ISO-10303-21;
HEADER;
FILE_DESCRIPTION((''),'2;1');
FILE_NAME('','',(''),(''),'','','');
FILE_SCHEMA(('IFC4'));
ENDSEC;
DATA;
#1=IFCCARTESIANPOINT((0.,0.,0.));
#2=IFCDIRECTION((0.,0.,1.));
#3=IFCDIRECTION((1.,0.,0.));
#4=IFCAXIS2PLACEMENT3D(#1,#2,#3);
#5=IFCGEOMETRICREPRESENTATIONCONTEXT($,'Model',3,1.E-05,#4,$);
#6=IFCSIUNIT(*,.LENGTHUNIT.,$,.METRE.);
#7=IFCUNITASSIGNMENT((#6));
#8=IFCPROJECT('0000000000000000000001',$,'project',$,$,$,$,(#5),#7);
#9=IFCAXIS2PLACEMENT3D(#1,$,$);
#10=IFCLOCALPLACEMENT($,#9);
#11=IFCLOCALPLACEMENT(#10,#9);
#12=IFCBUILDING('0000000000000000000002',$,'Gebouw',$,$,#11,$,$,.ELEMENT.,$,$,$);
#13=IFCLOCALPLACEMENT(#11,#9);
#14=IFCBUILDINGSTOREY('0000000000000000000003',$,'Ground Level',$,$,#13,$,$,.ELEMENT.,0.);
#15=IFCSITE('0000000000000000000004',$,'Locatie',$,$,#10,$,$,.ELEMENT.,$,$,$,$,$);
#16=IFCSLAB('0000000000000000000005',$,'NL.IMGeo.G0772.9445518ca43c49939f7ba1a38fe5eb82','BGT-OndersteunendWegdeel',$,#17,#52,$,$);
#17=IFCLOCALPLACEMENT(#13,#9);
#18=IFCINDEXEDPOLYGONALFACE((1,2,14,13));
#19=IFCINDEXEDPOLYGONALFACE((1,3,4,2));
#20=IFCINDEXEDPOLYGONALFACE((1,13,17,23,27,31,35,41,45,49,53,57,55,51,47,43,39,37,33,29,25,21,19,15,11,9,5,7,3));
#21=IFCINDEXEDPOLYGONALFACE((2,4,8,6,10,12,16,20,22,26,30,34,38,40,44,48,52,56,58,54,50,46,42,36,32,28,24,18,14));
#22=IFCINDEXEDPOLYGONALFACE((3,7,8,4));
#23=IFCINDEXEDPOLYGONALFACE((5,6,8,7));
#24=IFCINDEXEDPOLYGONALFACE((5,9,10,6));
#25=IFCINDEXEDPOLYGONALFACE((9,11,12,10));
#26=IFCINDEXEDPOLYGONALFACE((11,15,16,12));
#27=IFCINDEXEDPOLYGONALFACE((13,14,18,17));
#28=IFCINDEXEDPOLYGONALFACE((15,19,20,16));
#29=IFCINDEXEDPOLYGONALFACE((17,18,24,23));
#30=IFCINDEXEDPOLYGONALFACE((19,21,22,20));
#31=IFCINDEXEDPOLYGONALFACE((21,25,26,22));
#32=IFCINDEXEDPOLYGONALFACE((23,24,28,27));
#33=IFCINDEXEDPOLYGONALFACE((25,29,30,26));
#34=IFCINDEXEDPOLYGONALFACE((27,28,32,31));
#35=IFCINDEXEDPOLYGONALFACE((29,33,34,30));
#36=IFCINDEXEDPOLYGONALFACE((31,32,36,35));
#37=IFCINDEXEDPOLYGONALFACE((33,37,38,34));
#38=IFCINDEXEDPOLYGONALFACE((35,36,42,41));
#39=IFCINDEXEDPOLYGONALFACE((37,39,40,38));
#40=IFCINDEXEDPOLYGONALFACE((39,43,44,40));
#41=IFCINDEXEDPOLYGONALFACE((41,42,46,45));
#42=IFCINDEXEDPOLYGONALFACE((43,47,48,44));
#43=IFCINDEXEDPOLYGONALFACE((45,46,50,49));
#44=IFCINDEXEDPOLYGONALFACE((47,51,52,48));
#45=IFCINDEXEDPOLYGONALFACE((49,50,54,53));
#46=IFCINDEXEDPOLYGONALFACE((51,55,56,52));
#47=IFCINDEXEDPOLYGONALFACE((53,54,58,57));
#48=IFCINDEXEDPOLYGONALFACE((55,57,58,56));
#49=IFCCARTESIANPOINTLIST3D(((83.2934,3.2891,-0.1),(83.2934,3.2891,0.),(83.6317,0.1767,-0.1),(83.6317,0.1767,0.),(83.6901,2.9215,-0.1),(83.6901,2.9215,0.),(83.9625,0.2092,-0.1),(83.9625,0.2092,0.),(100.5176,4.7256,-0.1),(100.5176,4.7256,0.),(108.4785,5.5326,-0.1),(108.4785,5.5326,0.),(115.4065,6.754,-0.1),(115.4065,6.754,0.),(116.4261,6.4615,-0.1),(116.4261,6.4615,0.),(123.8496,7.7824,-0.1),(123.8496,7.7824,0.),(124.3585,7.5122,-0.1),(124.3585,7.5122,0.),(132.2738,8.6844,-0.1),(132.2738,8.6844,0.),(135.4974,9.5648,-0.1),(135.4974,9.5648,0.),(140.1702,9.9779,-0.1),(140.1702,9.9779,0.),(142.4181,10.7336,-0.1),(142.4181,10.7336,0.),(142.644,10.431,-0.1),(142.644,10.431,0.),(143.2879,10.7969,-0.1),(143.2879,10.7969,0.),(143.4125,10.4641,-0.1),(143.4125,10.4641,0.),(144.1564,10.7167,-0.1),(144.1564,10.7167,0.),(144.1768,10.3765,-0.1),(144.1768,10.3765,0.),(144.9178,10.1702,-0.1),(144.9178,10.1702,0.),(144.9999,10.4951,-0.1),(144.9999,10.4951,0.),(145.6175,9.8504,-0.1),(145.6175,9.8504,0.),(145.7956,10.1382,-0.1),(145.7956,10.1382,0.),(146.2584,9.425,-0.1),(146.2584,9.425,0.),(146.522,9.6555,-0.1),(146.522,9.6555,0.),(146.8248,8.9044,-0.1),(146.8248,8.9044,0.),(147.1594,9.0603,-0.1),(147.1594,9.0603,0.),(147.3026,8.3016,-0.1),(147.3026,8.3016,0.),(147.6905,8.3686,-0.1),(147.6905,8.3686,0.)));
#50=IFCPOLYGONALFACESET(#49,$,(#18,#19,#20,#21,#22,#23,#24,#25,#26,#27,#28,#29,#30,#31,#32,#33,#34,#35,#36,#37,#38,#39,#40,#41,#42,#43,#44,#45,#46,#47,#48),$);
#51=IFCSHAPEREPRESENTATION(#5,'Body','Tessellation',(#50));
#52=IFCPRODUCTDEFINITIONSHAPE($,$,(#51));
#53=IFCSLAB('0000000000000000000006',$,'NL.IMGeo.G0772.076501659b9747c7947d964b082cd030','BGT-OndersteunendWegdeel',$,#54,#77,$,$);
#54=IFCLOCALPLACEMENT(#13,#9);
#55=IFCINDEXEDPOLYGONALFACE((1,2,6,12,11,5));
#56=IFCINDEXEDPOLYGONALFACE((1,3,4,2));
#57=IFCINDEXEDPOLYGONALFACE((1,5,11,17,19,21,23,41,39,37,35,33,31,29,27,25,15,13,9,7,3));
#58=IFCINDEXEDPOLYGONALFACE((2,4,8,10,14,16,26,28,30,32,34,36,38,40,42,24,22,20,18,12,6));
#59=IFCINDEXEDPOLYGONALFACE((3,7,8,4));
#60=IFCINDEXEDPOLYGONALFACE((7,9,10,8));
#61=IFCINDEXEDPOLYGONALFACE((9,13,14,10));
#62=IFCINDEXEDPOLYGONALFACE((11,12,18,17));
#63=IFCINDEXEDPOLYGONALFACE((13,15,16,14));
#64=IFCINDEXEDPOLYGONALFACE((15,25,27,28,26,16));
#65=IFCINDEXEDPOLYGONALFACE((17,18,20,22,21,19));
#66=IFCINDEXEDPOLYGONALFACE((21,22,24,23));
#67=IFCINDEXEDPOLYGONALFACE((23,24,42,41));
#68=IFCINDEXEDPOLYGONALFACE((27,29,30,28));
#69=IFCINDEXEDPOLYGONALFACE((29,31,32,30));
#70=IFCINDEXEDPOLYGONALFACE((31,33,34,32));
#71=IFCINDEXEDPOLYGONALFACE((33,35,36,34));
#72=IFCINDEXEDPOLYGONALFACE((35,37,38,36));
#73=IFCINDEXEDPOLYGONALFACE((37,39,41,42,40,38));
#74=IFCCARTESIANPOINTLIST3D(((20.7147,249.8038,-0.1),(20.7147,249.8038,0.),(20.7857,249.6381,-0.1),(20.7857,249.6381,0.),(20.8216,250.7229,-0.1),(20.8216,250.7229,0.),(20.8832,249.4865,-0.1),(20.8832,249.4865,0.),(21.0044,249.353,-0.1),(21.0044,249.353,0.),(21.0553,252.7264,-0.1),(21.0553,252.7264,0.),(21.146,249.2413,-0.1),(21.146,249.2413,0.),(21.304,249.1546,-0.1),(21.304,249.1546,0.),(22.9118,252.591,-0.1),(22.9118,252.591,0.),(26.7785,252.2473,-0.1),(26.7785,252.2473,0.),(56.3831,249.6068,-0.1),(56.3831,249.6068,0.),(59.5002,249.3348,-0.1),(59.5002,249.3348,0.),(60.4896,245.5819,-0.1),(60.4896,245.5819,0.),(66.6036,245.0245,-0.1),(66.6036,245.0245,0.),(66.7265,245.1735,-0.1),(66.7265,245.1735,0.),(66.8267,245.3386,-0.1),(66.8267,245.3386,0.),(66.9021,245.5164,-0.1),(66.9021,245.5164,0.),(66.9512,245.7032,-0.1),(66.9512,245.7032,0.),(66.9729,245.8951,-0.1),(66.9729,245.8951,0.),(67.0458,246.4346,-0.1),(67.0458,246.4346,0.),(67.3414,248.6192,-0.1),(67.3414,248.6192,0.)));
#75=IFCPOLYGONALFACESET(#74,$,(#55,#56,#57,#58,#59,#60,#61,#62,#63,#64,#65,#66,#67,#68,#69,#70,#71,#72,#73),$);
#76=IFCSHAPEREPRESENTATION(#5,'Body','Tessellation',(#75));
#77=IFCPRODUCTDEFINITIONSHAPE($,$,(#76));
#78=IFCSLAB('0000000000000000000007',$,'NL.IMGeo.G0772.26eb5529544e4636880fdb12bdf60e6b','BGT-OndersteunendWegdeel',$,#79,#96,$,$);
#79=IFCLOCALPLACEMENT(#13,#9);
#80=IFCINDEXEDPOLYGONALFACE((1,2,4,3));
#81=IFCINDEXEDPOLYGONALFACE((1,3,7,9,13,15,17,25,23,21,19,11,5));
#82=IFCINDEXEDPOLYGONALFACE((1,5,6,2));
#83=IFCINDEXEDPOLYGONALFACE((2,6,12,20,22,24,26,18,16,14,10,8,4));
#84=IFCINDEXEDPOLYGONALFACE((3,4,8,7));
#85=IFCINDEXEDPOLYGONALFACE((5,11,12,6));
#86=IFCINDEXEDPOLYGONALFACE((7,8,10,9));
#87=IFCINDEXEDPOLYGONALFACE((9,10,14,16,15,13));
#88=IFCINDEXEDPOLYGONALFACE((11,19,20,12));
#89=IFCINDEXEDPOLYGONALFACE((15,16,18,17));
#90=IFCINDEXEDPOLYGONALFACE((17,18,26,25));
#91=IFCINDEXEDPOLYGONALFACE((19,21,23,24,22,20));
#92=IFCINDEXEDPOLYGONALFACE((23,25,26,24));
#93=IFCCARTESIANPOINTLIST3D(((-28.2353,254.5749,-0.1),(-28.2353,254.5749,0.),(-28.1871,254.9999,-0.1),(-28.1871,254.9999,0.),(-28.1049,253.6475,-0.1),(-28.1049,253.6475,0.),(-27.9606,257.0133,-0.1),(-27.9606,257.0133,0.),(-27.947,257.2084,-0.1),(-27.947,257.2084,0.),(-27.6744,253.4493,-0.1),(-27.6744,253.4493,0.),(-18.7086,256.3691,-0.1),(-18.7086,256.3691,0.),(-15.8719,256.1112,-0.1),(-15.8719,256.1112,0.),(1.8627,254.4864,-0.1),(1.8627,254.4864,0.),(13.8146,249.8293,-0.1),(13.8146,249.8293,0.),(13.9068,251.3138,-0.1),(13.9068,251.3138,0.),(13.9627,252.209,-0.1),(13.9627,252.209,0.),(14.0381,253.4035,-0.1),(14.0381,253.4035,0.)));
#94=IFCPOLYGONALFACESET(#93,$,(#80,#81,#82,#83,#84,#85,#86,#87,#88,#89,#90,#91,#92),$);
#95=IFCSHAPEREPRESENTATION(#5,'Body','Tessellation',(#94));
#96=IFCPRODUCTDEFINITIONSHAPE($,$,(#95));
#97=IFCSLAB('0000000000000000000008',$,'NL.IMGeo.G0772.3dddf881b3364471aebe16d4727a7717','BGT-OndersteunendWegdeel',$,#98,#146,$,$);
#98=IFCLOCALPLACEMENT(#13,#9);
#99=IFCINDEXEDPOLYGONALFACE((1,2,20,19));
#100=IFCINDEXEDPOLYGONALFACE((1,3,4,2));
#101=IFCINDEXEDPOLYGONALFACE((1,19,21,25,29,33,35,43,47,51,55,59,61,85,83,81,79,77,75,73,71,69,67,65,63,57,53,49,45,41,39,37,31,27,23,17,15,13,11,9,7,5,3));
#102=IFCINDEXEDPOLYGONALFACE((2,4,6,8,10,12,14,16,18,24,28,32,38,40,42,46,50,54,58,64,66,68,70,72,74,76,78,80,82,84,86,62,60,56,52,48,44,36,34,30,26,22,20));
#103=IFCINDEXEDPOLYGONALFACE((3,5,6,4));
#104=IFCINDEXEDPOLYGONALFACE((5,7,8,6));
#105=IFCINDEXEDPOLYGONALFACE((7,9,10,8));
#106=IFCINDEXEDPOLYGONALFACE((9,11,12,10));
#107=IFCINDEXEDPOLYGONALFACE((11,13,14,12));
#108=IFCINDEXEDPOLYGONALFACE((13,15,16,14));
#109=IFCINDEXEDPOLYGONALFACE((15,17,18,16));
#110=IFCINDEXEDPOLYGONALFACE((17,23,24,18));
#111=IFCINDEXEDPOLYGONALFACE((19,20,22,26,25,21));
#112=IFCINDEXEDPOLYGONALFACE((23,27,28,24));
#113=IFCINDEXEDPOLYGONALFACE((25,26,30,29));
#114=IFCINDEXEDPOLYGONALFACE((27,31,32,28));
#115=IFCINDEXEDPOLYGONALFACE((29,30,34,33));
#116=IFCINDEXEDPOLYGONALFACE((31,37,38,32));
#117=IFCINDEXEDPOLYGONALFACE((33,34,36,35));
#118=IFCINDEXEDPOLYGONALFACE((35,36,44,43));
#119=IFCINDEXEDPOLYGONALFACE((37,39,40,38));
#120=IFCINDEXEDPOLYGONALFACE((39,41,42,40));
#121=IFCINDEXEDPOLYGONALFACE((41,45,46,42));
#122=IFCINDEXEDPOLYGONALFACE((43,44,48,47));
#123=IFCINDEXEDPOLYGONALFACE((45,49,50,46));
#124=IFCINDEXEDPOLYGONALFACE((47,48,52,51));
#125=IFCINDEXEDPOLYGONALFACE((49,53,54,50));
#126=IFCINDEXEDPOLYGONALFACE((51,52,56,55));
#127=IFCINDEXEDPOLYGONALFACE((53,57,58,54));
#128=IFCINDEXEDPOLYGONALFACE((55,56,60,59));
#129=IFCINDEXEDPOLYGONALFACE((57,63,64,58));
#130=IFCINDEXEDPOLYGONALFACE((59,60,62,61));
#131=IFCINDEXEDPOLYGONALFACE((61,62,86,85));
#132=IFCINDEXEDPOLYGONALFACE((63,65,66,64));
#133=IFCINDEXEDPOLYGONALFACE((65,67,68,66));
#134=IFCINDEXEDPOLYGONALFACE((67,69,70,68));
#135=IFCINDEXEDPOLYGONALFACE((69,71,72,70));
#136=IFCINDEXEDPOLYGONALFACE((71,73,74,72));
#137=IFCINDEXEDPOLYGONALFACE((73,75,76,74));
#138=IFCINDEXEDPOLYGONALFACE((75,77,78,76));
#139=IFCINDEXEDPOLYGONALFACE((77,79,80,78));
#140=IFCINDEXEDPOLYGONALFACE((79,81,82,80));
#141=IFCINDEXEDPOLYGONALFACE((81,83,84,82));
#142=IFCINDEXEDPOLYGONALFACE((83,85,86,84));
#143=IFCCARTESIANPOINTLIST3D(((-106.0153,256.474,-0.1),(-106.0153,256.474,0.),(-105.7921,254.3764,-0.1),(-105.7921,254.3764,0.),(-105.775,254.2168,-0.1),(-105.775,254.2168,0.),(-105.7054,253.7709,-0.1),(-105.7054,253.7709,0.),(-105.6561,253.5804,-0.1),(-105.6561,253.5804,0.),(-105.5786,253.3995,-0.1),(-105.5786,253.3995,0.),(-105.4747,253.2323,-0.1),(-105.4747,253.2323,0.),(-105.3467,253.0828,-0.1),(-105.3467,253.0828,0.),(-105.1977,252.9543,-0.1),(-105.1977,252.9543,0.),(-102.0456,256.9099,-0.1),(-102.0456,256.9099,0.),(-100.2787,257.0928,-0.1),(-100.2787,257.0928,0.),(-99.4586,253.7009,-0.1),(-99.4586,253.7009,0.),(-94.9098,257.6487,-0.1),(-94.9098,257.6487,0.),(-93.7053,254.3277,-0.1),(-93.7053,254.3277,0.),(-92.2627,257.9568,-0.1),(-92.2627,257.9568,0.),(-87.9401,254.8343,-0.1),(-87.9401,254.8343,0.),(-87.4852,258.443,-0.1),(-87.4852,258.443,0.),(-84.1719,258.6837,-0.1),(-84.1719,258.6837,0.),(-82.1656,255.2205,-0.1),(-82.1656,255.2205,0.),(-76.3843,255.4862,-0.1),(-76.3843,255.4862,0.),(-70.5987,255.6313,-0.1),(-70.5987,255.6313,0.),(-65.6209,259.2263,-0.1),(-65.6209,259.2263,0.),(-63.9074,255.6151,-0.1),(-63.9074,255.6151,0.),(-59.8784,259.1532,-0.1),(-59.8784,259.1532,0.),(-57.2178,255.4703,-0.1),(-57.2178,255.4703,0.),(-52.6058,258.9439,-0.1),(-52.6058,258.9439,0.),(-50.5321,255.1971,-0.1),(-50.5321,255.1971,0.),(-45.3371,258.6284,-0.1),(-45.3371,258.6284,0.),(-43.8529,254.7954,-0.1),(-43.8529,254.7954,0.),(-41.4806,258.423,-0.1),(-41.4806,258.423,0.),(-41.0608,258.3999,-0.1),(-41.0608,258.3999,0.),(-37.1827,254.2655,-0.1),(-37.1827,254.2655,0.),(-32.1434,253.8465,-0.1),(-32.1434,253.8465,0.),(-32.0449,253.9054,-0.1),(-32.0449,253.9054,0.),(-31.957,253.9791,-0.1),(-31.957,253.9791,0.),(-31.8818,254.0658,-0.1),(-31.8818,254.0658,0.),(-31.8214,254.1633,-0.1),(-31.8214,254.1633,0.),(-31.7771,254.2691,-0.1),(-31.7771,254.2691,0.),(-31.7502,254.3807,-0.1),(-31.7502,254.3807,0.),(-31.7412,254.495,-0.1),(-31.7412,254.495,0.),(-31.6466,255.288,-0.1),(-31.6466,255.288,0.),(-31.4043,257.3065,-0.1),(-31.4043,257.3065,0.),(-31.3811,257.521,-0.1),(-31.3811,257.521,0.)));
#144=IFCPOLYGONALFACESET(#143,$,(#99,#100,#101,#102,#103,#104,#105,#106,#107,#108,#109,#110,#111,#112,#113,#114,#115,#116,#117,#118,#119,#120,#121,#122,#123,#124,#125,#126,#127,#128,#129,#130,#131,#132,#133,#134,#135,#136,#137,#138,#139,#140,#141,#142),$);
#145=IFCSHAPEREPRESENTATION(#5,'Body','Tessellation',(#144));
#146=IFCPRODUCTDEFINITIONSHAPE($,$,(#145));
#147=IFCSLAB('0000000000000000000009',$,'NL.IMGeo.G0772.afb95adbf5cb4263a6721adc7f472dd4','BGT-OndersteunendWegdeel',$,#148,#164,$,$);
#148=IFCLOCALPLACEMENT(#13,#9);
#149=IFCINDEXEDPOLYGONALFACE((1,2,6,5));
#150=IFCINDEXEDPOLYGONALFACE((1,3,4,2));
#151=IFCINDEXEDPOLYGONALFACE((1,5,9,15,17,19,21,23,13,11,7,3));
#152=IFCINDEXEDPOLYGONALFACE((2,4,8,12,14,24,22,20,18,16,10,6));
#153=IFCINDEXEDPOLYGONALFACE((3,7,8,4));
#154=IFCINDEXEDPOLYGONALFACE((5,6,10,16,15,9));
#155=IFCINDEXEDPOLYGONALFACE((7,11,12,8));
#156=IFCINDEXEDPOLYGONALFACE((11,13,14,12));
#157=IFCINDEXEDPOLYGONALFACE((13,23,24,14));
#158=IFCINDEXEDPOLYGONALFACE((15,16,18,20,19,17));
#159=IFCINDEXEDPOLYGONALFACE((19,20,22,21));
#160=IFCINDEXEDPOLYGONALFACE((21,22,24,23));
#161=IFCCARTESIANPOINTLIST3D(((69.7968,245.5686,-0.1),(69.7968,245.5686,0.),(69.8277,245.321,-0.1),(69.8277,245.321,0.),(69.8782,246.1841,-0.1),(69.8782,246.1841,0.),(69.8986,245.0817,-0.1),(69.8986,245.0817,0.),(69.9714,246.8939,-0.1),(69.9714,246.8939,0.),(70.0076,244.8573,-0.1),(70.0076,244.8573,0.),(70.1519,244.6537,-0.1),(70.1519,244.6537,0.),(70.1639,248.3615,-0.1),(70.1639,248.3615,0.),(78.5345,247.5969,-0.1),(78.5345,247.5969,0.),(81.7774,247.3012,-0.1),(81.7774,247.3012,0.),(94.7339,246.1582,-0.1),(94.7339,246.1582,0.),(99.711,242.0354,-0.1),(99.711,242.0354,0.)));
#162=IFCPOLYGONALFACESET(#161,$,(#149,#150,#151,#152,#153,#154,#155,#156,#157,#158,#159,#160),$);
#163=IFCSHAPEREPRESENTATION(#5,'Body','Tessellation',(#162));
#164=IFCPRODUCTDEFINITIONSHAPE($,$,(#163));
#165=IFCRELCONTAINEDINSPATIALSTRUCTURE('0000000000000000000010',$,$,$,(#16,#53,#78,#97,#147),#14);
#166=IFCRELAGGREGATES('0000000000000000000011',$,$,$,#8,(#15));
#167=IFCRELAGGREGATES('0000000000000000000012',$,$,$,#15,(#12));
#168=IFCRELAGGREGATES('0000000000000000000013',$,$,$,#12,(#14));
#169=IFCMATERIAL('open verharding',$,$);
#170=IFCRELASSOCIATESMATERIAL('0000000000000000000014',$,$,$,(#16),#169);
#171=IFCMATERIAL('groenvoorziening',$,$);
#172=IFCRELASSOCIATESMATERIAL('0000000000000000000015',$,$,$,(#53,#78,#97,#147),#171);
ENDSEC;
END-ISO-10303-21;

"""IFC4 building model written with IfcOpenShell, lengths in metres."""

from ifc_helpers import new_model, si_unit, frame, origin, origin_with_axes, place, context, project, spatial, polyline, outline, extrude, material, element, save


model = new_model("IFC4")

# Units and contexts
model_context = context("Model", 3, precision=1e-05, world=origin_with_axes())
ifc_project = project(units=[si_unit("LENGTHUNIT", "METRE")], contexts=[model_context])

# Site, building, storey
site_placement = place(None, origin())
site = spatial("IfcSite", under=ifc_project, at=site_placement, Name="Locatie", CompositionType="ELEMENT")
building_placement = place(site_placement, origin())
building = spatial("IfcBuilding", under=site, at=building_placement, Name="Gebouw", CompositionType="ELEMENT")
storey_placement = place(building_placement, origin())
storey = spatial("IfcBuildingStorey", under=building, at=storey_placement, Name="Ground Level", CompositionType="ELEMENT", Elevation=0.0)

# Slabs
ifc_material_1 = material(Name="open verharding")
ifc_material_2 = material(Name="groenvoorziening")
slab_1_placement = place(storey_placement, origin())
element("IfcSlab", 1, at=slab_1_placement, inside=storey, material=ifc_material_1, Name="NL.IMGeo.G0772.9445518ca43c49939f7ba1a38fe5eb82", Description="BGT-OndersteunendWegdeel", context=model_context, shape_type="SweptSolid", body=[
    extrude(outline(polyline([(115.4065, 6.754), (123.8496, 7.7824), (135.4974, 9.5648), (142.4181, 10.7336), (143.2879, 10.7969), (144.1564, 10.7167), (144.9999, 10.4951), (145.7956, 10.1382), (146.522, 9.6555), (147.1594, 9.0603), (147.6905, 8.3686), (147.3026, 8.3016), (146.8248, 8.9044), (146.2584, 9.425), (145.6175, 9.8504), (144.9178, 10.1702), (144.1768, 10.3765), (143.4125, 10.4641), (142.644, 10.431), (140.1702, 9.9779), (132.2738, 8.6844), (124.3585, 7.5122), (116.4261, 6.4615), (108.4785, 5.5326), (100.5176, 4.7256), (83.6901, 2.9215), (83.9625, 0.2092), (83.6317, 0.1767), (83.2934, 3.2891), (115.4065, 6.754)])), frame((0.0, 0.0, -0.1), z_axis=(0.0, 0.0, 1.0), x_axis=(1.0, 0.0, 0.0)), (0.0, 0.0, 1.0), 0.1),
])
slab_2_placement = place(storey_placement, origin())
element("IfcSlab", 2, at=slab_2_placement, inside=storey, material=ifc_material_2, Name="NL.IMGeo.G0772.076501659b9747c7947d964b082cd030", Description="BGT-OndersteunendWegdeel", context=model_context, shape_type="SweptSolid", body=[
    extrude(outline(polyline([(56.3831, 249.6068), (59.5002, 249.3348), (67.3414, 248.6192), (67.0458, 246.4346), (66.9729, 245.8951), (66.9512, 245.7032), (66.9021, 245.5164), (66.8267, 245.3386), (66.7265, 245.1735), (66.6036, 245.0245), (60.4896, 245.5819), (21.304, 249.1546), (21.146, 249.2413), (21.0044, 249.353), (20.8832, 249.4865), (20.7857, 249.6381), (20.7147, 249.8038), (20.8216, 250.7229), (21.0553, 252.7264), (22.9118, 252.591), (26.7785, 252.2473), (56.3831, 249.6068)])), frame((0.0, 0.0, -0.1), z_axis=(0.0, 0.0, 1.0), x_axis=(1.0, 0.0, 0.0)), (0.0, 0.0, 1.0), 0.1),
])
slab_3_placement = place(storey_placement, origin())
element("IfcSlab", 3, at=slab_3_placement, inside=storey, material=ifc_material_2, Name="NL.IMGeo.G0772.26eb5529544e4636880fdb12bdf60e6b", Description="BGT-OndersteunendWegdeel", context=model_context, shape_type="SweptSolid", body=[
    extrude(outline(polyline([(1.8627, 254.4864), (14.0381, 253.4035), (13.9627, 252.209), (13.9068, 251.3138), (13.8146, 249.8293), (-27.6744, 253.4493), (-28.1049, 253.6475), (-28.2353, 254.5749), (-28.1871, 254.9999), (-27.9606, 257.0133), (-27.947, 257.2084), (-18.7086, 256.3691), (-15.8719, 256.1112), (1.8627, 254.4864)])), frame((0.0, 0.0, -0.1), z_axis=(0.0, 0.0, 1.0), x_axis=(1.0, 0.0, 0.0)), (0.0, 0.0, 1.0), 0.1),
])
slab_4_placement = place(storey_placement, origin())
element("IfcSlab", 4, at=slab_4_placement, inside=storey, material=ifc_material_2, Name="NL.IMGeo.G0772.3dddf881b3364471aebe16d4727a7717", Description="BGT-OndersteunendWegdeel", context=model_context, shape_type="SweptSolid", body=[
    extrude(outline(polyline([(-65.6209, 259.2263), (-59.8784, 259.1532), (-52.6058, 258.9439), (-45.3371, 258.6284), (-41.4806, 258.423), (-41.0608, 258.3999), (-31.3811, 257.521), (-31.4043, 257.3065), (-31.6466, 255.288), (-31.7412, 254.495), (-31.7502, 254.3807), (-31.7771, 254.2691), (-31.8214, 254.1633), (-31.8818, 254.0658), (-31.957, 253.9791), (-32.0449, 253.9054), (-32.1434, 253.8465), (-37.1827, 254.2655), (-43.8529, 254.7954), (-50.5321, 255.1971), (-57.2178, 255.4703), (-63.9074, 255.6151), (-70.5987, 255.6313), (-76.3843, 255.4862), (-82.1656, 255.2205), (-87.9401, 254.8343), (-93.7053, 254.3277), (-99.4586, 253.7009), (-105.1977, 252.9543), (-105.3467, 253.0828), (-105.4747, 253.2323), (-105.5786, 253.3995), (-105.6561, 253.5804), (-105.7054, 253.7709), (-105.775, 254.2168), (-105.7921, 254.3764), (-106.0153, 256.474), (-102.0456, 256.9099), (-100.2787, 257.0928), (-94.9098, 257.6487), (-92.2627, 257.9568), (-87.4852, 258.443), (-84.1719, 258.6837), (-65.6209, 259.2263)])), frame((0.0, 0.0, -0.1), z_axis=(0.0, 0.0, 1.0), x_axis=(1.0, 0.0, 0.0)), (0.0, 0.0, 1.0), 0.1),
])
slab_5_placement = place(storey_placement, origin())
element("IfcSlab", 5, at=slab_5_placement, inside=storey, material=ifc_material_2, Name="NL.IMGeo.G0772.afb95adbf5cb4263a6721adc7f472dd4", Description="BGT-OndersteunendWegdeel", context=model_context, shape_type="SweptSolid", body=[
    extrude(outline(polyline([(70.1519, 244.6537), (70.0076, 244.8573), (69.8986, 245.0817), (69.8277, 245.321), (69.7968, 245.5686), (69.8782, 246.1841), (69.9714, 246.8939), (70.1639, 248.3615), (78.5345, 247.5969), (81.7774, 247.3012), (94.7339, 246.1582), (99.711, 242.0354), (70.1519, 244.6537)])), frame((0.0, 0.0, -0.1), z_axis=(0.0, 0.0, 1.0), x_axis=(1.0, 0.0, 0.0)), (0.0, 0.0, 1.0), 0.1),
])

save(model, "model.ifc")
